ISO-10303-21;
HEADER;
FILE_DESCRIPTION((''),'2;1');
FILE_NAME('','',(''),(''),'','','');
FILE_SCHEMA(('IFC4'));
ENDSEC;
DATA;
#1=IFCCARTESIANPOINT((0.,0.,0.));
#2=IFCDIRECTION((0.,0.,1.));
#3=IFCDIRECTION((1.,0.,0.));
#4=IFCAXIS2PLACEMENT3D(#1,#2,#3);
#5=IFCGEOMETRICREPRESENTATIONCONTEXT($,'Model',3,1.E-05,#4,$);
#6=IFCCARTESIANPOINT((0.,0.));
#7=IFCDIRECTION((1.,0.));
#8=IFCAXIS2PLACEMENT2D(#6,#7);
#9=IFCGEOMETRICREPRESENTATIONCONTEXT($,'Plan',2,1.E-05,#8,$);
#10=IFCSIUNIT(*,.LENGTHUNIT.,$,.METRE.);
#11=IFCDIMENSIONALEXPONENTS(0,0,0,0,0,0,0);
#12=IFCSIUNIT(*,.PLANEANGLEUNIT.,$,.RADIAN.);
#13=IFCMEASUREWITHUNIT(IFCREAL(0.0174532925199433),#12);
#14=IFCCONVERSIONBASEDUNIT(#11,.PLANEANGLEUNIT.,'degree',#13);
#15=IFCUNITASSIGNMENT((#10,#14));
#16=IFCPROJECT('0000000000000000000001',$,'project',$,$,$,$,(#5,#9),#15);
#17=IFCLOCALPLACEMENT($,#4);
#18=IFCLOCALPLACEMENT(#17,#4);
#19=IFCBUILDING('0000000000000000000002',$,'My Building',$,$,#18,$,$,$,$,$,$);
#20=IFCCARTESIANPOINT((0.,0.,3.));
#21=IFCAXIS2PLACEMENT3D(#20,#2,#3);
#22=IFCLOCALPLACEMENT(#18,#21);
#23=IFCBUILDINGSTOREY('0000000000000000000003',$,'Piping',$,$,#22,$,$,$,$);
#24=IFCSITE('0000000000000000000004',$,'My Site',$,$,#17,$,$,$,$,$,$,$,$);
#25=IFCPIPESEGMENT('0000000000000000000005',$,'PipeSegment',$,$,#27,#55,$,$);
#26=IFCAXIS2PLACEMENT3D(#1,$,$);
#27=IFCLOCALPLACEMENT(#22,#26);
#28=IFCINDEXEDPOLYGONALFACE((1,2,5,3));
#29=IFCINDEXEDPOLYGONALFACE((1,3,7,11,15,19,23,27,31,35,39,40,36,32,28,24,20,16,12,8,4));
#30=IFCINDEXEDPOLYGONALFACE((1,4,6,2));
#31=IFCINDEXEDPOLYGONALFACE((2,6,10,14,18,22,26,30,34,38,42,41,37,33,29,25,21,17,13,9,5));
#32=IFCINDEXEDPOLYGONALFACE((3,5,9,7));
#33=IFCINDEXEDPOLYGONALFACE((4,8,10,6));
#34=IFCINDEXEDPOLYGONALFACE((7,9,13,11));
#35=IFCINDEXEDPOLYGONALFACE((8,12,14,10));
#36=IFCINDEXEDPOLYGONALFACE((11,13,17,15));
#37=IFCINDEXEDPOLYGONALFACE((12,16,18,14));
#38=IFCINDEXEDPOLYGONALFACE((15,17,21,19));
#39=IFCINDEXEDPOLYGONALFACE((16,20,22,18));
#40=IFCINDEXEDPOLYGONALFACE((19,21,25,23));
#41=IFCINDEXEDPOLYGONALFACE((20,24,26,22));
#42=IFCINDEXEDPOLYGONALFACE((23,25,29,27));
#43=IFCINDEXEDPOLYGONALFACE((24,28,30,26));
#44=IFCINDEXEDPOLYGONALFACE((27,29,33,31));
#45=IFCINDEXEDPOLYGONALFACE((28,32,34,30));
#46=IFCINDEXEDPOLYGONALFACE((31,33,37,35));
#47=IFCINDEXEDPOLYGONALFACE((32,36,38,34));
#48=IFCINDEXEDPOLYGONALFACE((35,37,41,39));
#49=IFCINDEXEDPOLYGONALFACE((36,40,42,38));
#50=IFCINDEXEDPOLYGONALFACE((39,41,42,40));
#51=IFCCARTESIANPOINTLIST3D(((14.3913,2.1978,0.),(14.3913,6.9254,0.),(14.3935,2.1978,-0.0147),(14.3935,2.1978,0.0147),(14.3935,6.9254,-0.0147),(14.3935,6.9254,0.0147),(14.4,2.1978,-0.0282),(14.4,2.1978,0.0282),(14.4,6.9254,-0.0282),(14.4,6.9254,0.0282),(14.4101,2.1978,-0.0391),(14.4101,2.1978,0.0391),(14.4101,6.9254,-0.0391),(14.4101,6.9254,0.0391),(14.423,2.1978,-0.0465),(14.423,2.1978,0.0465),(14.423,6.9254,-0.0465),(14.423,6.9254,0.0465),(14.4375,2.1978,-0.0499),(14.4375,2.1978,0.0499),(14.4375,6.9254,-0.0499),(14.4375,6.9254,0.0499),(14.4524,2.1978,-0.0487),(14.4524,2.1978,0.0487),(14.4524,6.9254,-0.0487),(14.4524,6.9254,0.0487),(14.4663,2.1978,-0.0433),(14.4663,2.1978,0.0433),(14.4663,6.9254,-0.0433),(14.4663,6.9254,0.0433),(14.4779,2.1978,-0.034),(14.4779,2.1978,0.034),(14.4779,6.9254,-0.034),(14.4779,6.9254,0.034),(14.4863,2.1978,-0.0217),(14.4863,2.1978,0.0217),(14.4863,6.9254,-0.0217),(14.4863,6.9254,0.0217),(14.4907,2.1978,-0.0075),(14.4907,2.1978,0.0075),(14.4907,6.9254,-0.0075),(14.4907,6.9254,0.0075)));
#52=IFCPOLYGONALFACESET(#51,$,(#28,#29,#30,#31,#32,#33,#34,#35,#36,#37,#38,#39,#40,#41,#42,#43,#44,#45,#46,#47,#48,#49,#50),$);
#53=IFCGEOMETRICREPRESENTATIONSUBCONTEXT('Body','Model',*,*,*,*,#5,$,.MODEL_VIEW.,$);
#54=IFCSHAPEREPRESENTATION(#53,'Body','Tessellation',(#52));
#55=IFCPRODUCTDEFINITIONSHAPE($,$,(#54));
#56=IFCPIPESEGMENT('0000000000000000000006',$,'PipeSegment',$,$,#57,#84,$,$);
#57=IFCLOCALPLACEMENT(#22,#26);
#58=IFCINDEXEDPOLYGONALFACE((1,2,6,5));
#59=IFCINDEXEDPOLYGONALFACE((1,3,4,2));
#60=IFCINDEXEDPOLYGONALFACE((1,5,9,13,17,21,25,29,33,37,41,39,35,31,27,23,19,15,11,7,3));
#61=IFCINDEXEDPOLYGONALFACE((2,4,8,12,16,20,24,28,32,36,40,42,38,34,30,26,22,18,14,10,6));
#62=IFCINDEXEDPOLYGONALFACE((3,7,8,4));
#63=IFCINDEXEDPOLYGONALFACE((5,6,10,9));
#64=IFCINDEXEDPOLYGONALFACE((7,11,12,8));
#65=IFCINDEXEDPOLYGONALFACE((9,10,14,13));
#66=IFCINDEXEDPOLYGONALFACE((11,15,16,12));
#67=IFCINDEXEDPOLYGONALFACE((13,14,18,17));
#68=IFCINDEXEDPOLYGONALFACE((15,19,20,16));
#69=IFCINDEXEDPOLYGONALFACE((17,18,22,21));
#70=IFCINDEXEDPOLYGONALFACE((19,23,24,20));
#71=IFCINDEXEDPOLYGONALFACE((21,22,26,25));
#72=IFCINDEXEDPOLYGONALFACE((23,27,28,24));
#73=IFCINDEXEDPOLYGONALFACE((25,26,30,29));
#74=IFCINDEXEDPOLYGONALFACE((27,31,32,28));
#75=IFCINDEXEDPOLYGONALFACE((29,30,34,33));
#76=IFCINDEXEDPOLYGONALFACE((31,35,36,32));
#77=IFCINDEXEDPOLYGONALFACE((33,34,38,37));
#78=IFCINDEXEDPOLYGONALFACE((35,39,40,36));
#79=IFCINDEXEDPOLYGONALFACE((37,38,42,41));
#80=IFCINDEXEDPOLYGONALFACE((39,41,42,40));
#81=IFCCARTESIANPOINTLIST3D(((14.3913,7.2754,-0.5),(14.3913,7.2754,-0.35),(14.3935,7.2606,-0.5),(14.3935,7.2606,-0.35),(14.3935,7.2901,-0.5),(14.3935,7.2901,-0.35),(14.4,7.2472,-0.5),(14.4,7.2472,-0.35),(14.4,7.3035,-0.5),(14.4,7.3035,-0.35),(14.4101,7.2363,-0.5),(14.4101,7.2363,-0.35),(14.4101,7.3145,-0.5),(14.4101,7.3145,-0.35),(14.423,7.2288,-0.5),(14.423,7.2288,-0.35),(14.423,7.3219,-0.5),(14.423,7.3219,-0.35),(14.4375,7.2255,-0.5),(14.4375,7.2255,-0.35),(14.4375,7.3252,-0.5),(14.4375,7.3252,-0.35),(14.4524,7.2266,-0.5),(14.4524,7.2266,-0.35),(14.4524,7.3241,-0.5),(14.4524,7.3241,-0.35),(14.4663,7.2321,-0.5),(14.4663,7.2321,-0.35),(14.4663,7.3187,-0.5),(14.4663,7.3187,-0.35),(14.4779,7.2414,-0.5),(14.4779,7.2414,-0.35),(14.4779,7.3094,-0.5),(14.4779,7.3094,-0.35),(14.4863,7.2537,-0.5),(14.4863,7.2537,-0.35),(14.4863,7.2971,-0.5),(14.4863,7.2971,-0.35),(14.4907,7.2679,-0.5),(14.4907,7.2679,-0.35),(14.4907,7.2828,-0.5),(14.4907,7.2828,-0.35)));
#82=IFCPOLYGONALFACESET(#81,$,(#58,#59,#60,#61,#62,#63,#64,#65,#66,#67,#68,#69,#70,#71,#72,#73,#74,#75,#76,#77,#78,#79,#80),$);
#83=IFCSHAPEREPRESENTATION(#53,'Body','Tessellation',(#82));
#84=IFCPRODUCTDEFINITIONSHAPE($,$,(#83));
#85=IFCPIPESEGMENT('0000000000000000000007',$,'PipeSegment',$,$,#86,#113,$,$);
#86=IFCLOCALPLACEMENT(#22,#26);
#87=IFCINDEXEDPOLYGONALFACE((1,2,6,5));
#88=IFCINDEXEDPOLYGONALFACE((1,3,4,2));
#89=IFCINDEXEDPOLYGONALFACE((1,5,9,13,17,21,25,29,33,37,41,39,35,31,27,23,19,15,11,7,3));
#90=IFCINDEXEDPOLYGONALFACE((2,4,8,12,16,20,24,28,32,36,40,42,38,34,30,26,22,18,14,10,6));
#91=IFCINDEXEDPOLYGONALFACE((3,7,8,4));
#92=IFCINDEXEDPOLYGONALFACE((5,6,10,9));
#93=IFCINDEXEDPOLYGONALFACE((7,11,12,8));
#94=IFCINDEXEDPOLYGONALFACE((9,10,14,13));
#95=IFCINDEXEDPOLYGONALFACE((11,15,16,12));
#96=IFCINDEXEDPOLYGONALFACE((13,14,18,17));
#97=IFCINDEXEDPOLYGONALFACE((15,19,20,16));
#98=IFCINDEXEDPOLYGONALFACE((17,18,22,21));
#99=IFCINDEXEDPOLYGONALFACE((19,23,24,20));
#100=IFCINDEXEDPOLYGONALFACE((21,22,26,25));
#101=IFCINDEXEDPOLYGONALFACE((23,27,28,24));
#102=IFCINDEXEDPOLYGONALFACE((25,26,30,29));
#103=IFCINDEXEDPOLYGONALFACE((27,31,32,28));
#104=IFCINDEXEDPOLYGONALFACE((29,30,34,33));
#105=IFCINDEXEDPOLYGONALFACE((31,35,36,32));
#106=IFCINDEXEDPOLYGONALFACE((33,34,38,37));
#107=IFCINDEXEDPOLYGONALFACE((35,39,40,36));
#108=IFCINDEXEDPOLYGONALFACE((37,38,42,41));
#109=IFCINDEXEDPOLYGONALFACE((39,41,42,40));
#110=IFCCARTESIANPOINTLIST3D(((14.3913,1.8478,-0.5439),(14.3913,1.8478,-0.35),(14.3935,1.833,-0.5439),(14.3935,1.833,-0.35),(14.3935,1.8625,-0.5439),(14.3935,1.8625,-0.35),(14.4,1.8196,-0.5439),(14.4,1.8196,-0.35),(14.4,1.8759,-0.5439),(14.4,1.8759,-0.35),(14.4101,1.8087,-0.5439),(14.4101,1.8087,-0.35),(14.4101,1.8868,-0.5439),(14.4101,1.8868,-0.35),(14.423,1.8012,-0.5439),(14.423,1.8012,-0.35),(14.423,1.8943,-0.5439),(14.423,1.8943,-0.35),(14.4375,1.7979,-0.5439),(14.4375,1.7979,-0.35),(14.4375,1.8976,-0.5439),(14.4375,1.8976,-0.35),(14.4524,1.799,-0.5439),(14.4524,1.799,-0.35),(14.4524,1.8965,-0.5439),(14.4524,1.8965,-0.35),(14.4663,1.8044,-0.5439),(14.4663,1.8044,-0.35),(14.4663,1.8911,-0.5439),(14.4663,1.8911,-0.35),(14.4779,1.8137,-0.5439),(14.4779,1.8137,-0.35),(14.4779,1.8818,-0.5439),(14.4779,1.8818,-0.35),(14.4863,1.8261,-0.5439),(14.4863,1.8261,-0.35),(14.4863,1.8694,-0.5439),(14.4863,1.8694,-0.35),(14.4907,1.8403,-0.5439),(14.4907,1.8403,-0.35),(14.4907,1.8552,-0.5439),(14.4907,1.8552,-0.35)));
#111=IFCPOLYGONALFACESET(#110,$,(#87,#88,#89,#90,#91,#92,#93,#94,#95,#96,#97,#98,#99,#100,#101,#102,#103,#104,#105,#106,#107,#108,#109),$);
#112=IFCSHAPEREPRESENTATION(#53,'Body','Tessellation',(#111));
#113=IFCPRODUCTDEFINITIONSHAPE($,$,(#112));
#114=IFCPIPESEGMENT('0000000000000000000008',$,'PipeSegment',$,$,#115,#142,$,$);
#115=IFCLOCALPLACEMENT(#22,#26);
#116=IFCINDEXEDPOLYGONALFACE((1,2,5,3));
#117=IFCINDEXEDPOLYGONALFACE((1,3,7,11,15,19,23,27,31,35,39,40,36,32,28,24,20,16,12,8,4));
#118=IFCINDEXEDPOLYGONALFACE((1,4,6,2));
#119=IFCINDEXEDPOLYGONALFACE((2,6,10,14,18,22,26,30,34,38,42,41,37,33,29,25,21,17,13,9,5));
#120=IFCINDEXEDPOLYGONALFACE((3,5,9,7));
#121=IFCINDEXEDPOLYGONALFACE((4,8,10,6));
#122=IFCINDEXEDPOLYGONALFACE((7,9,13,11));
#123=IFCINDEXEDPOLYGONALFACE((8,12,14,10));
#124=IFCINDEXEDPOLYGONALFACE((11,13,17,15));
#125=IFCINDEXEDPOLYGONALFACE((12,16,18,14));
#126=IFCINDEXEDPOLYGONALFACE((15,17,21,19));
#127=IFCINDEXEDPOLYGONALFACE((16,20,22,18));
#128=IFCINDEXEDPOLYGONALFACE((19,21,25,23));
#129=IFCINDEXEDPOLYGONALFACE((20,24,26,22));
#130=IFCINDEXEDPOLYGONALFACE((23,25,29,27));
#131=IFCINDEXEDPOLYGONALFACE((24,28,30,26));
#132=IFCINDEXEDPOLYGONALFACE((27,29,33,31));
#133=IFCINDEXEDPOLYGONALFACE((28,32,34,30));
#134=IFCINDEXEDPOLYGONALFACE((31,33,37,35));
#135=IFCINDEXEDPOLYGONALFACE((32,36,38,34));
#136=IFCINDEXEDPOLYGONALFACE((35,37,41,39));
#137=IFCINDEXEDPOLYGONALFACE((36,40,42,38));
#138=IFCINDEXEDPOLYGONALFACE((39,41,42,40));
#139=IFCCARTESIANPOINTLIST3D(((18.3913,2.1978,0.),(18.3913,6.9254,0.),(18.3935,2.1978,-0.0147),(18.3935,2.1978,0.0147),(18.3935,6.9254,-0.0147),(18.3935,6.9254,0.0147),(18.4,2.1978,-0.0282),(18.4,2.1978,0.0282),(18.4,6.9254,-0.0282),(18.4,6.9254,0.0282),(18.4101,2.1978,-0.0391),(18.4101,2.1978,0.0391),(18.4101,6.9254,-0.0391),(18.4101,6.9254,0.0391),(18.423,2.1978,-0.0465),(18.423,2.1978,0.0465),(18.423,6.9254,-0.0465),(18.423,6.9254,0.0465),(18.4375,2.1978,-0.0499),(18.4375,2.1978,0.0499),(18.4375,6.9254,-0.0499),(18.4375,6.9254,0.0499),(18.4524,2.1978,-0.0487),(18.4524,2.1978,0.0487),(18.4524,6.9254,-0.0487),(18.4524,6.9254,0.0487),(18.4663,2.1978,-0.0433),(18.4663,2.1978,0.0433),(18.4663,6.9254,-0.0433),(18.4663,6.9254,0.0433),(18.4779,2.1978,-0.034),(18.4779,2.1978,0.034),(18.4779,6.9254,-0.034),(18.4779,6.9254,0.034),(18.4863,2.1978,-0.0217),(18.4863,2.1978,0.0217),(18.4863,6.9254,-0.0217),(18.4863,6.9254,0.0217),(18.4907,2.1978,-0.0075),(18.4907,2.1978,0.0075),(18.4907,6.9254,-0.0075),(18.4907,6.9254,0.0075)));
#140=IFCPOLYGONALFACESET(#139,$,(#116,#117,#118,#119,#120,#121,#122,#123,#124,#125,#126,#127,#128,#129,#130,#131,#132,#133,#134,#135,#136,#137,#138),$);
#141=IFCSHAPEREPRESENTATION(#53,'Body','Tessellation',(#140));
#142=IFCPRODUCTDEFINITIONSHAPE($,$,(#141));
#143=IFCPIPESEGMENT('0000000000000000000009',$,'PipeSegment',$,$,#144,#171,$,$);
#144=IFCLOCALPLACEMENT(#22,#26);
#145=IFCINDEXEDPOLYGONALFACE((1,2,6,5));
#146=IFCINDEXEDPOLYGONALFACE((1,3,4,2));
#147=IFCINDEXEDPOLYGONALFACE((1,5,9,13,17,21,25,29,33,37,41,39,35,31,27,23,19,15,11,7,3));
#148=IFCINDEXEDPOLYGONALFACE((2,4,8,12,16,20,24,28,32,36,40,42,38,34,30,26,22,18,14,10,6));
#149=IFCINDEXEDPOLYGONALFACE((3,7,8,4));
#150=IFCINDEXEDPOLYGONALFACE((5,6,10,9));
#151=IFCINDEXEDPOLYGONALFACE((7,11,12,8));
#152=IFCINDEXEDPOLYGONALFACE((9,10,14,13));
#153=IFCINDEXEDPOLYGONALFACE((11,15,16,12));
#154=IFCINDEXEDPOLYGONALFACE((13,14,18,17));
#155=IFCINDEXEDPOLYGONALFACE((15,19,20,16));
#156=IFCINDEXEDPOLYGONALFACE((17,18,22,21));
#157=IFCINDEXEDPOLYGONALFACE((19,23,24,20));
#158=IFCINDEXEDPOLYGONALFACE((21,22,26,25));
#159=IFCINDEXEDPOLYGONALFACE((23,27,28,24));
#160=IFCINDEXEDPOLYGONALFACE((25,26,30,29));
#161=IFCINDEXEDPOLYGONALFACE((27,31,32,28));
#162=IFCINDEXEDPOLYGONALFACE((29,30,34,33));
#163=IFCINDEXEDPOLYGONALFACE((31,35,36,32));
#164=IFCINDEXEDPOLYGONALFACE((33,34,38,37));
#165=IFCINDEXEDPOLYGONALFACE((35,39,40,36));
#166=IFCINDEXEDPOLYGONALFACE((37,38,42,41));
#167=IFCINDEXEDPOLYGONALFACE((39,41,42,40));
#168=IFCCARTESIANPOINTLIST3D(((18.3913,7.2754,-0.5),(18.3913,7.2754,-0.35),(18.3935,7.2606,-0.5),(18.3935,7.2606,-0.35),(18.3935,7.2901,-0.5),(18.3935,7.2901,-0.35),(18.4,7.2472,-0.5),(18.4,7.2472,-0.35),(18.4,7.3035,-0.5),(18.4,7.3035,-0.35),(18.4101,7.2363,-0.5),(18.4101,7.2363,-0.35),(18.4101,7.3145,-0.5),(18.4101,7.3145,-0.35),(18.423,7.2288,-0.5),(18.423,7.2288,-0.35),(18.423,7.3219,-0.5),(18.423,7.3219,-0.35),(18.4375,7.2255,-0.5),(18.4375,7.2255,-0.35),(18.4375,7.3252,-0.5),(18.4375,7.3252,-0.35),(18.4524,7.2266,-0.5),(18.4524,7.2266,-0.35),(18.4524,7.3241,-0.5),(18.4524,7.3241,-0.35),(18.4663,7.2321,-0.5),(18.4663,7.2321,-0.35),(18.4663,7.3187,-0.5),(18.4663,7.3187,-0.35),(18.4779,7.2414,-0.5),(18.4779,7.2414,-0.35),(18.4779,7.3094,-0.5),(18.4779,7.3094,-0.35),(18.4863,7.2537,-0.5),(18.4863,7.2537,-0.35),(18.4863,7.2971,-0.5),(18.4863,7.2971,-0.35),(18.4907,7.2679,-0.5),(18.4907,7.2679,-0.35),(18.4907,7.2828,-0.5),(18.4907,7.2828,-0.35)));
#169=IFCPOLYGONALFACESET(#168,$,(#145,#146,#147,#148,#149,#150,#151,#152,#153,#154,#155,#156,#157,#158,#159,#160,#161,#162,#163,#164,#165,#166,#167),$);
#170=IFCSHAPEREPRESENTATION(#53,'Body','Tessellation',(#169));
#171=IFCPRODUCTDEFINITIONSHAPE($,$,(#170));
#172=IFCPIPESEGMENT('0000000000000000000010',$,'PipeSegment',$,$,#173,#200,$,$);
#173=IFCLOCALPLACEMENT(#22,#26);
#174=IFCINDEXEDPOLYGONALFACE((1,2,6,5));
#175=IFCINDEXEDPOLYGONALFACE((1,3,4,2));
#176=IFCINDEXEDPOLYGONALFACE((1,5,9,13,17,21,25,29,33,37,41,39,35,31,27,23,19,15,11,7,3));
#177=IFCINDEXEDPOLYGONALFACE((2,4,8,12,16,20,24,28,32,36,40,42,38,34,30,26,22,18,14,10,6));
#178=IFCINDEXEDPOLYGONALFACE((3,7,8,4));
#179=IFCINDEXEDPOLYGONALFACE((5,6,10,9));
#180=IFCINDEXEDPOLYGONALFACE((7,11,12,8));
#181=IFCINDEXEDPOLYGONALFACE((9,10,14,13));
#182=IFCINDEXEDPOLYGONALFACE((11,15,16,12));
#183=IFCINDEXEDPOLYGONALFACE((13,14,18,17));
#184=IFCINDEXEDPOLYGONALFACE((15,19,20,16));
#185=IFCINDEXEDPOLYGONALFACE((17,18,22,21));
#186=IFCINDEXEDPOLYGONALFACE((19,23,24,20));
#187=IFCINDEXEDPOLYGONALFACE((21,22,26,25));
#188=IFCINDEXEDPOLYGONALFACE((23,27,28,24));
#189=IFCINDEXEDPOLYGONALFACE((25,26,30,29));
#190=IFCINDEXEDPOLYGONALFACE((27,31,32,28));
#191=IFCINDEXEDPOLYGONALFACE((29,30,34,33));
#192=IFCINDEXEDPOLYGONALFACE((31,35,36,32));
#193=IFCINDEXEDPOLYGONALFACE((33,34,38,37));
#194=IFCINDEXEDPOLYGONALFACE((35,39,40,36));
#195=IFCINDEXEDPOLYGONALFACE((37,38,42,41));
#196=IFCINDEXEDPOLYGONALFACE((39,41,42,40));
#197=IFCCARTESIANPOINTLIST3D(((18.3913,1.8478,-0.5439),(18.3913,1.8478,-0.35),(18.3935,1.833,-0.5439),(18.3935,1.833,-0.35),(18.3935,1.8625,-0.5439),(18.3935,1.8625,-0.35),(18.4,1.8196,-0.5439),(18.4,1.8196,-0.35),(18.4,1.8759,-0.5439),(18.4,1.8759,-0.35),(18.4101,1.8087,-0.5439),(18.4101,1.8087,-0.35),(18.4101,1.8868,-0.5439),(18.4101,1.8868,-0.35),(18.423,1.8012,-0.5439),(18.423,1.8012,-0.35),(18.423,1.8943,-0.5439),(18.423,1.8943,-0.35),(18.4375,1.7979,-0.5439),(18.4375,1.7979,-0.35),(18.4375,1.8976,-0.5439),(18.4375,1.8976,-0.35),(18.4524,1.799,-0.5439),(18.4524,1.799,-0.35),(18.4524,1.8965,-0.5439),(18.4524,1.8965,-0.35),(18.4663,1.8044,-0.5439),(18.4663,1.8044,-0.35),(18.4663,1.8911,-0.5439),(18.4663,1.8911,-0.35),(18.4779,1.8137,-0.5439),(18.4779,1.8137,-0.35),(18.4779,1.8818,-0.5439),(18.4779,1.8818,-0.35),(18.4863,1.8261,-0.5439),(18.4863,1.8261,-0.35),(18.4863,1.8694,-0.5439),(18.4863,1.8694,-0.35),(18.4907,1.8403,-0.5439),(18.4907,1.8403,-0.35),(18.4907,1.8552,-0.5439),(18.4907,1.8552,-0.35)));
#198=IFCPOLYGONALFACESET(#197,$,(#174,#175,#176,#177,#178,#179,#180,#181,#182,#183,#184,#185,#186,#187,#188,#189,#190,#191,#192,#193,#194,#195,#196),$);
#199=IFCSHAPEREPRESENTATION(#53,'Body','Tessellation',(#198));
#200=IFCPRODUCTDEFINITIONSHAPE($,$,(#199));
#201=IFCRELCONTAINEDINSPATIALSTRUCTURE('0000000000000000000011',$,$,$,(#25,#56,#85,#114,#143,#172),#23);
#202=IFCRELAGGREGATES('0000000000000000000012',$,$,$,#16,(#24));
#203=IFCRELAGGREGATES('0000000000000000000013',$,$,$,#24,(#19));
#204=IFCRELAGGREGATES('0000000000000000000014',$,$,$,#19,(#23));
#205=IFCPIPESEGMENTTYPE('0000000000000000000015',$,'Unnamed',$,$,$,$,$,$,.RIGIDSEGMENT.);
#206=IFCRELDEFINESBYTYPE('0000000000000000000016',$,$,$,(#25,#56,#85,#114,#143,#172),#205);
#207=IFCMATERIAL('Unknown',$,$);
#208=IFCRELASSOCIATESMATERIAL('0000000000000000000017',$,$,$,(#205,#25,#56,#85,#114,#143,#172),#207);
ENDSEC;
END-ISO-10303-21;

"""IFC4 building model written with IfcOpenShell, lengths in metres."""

from ifc_helpers import new_model, entity, si_unit, converted_unit, frame, origin_with_axes, origin_2d_with_axis, place, context, subcontext, project, spatial, circle, extrude, material, material_profile, profile_set, profile_usage, type_object, element, save


model = new_model("IFC4")

# Units and contexts
model_context = context("Model", 3, precision=1e-05, world=origin_with_axes())
plan_context = context("Plan", 2, precision=1e-05, world=origin_2d_with_axis())
body_context = subcontext(model_context, "Body", "Model", "MODEL_VIEW")
ifc_project = project(units=[si_unit("LENGTHUNIT", "METRE"), converted_unit("PLANEANGLEUNIT", "degree", entity("IfcReal", 0.0174532925199433), si_unit("PLANEANGLEUNIT", "RADIAN"), dimensions=[0, 0, 0, 0, 0, 0, 0])], contexts=[model_context, plan_context])

# Site, building, storey
site_placement = place(None, origin_with_axes())
site = spatial("IfcSite", under=ifc_project, at=site_placement, Name="My Site")
building_placement = place(site_placement, origin_with_axes())
building = spatial("IfcBuilding", under=site, at=building_placement, Name="My Building")
storey_placement = place(building_placement, frame((0.0, 0.0, 3.0), z_axis=(0.0, 0.0, 1.0), x_axis=(1.0, 0.0, 0.0)))
storey = spatial("IfcBuildingStorey", under=building, at=storey_placement, Name="Piping")

# Pipe segments
ifc_material = material(Name="Unknown")
ifc_material_profile = material_profile(ifc_material, circle(Radius=0.05))
ifc_profile_set = profile_set([ifc_material_profile])
pipe_segment_type = type_object("IfcPipeSegmentType", Name="Unnamed", PredefinedType="RIGIDSEGMENT", material=ifc_profile_set)
ifc_profile_usage_1 = profile_usage(ifc_profile_set, cardinal=5)
pipe_segment_1_placement = place(storey_placement, frame((14.4413, 2.1978, 0.0), z_axis=(0.0, 1.0, 0.0), x_axis=(-1.0, 0.0, 0.0)))
element("IfcPipeSegment", 1, at=pipe_segment_1_placement, inside=storey, type_object=pipe_segment_type, material=ifc_profile_usage_1, Name="PipeSegment", context=body_context, shape_type="SweptSolid", body=[
    extrude(circle(Radius=0.05), origin_with_axes(), (0.0, 0.0, 1.0), 4.7276),
])
ifc_profile_usage_2 = profile_usage(ifc_profile_set, cardinal=5)
pipe_segment_2_placement = place(storey_placement, frame((14.4413, 7.2754, -0.35), z_axis=(0.0, 0.0, -1.0), x_axis=(-1.0, 0.0, 0.0)))
element("IfcPipeSegment", 2, at=pipe_segment_2_placement, inside=storey, type_object=pipe_segment_type, material=ifc_profile_usage_2, Name="PipeSegment", context=body_context, shape_type="SweptSolid", body=[
    extrude(circle(Radius=0.05), origin_with_axes(), (0.0, 0.0, 1.0), 0.15),
])
ifc_profile_usage_3 = profile_usage(ifc_profile_set, cardinal=5)
pipe_segment_3_placement = place(storey_placement, frame((14.4413, 1.8478, -0.35), z_axis=(0.0, 0.0, -1.0), x_axis=(-1.0, 0.0, 0.0)))
element("IfcPipeSegment", 3, at=pipe_segment_3_placement, inside=storey, type_object=pipe_segment_type, material=ifc_profile_usage_3, Name="PipeSegment", context=body_context, shape_type="SweptSolid", body=[
    extrude(circle(Radius=0.05), origin_with_axes(), (0.0, 0.0, 1.0), 0.1939),
])
ifc_profile_usage_4 = profile_usage(ifc_profile_set, cardinal=5)
pipe_segment_4_placement = place(storey_placement, frame((18.4413, 2.1978, 0.0), z_axis=(0.0, 1.0, 0.0), x_axis=(-1.0, 0.0, 0.0)))
element("IfcPipeSegment", 4, at=pipe_segment_4_placement, inside=storey, type_object=pipe_segment_type, material=ifc_profile_usage_4, Name="PipeSegment", context=body_context, shape_type="SweptSolid", body=[
    extrude(circle(Radius=0.05), origin_with_axes(), (0.0, 0.0, 1.0), 4.7276),
])
ifc_profile_usage_5 = profile_usage(ifc_profile_set, cardinal=5)
pipe_segment_5_placement = place(storey_placement, frame((18.4413, 7.2754, -0.35), z_axis=(0.0, 0.0, -1.0), x_axis=(-1.0, 0.0, 0.0)))
element("IfcPipeSegment", 5, at=pipe_segment_5_placement, inside=storey, type_object=pipe_segment_type, material=ifc_profile_usage_5, Name="PipeSegment", context=body_context, shape_type="SweptSolid", body=[
    extrude(circle(Radius=0.05), origin_with_axes(), (0.0, 0.0, 1.0), 0.15),
])
ifc_profile_usage_6 = profile_usage(ifc_profile_set, cardinal=5)
pipe_segment_6_placement = place(storey_placement, frame((18.4413, 1.8478, -0.35), z_axis=(0.0, 0.0, -1.0), x_axis=(-1.0, 0.0, 0.0)))
element("IfcPipeSegment", 6, at=pipe_segment_6_placement, inside=storey, type_object=pipe_segment_type, material=ifc_profile_usage_6, Name="PipeSegment", context=body_context, shape_type="SweptSolid", body=[
    extrude(circle(Radius=0.05), origin_with_axes(), (0.0, 0.0, 1.0), 0.1939),
])

save(model, "model.ifc")
